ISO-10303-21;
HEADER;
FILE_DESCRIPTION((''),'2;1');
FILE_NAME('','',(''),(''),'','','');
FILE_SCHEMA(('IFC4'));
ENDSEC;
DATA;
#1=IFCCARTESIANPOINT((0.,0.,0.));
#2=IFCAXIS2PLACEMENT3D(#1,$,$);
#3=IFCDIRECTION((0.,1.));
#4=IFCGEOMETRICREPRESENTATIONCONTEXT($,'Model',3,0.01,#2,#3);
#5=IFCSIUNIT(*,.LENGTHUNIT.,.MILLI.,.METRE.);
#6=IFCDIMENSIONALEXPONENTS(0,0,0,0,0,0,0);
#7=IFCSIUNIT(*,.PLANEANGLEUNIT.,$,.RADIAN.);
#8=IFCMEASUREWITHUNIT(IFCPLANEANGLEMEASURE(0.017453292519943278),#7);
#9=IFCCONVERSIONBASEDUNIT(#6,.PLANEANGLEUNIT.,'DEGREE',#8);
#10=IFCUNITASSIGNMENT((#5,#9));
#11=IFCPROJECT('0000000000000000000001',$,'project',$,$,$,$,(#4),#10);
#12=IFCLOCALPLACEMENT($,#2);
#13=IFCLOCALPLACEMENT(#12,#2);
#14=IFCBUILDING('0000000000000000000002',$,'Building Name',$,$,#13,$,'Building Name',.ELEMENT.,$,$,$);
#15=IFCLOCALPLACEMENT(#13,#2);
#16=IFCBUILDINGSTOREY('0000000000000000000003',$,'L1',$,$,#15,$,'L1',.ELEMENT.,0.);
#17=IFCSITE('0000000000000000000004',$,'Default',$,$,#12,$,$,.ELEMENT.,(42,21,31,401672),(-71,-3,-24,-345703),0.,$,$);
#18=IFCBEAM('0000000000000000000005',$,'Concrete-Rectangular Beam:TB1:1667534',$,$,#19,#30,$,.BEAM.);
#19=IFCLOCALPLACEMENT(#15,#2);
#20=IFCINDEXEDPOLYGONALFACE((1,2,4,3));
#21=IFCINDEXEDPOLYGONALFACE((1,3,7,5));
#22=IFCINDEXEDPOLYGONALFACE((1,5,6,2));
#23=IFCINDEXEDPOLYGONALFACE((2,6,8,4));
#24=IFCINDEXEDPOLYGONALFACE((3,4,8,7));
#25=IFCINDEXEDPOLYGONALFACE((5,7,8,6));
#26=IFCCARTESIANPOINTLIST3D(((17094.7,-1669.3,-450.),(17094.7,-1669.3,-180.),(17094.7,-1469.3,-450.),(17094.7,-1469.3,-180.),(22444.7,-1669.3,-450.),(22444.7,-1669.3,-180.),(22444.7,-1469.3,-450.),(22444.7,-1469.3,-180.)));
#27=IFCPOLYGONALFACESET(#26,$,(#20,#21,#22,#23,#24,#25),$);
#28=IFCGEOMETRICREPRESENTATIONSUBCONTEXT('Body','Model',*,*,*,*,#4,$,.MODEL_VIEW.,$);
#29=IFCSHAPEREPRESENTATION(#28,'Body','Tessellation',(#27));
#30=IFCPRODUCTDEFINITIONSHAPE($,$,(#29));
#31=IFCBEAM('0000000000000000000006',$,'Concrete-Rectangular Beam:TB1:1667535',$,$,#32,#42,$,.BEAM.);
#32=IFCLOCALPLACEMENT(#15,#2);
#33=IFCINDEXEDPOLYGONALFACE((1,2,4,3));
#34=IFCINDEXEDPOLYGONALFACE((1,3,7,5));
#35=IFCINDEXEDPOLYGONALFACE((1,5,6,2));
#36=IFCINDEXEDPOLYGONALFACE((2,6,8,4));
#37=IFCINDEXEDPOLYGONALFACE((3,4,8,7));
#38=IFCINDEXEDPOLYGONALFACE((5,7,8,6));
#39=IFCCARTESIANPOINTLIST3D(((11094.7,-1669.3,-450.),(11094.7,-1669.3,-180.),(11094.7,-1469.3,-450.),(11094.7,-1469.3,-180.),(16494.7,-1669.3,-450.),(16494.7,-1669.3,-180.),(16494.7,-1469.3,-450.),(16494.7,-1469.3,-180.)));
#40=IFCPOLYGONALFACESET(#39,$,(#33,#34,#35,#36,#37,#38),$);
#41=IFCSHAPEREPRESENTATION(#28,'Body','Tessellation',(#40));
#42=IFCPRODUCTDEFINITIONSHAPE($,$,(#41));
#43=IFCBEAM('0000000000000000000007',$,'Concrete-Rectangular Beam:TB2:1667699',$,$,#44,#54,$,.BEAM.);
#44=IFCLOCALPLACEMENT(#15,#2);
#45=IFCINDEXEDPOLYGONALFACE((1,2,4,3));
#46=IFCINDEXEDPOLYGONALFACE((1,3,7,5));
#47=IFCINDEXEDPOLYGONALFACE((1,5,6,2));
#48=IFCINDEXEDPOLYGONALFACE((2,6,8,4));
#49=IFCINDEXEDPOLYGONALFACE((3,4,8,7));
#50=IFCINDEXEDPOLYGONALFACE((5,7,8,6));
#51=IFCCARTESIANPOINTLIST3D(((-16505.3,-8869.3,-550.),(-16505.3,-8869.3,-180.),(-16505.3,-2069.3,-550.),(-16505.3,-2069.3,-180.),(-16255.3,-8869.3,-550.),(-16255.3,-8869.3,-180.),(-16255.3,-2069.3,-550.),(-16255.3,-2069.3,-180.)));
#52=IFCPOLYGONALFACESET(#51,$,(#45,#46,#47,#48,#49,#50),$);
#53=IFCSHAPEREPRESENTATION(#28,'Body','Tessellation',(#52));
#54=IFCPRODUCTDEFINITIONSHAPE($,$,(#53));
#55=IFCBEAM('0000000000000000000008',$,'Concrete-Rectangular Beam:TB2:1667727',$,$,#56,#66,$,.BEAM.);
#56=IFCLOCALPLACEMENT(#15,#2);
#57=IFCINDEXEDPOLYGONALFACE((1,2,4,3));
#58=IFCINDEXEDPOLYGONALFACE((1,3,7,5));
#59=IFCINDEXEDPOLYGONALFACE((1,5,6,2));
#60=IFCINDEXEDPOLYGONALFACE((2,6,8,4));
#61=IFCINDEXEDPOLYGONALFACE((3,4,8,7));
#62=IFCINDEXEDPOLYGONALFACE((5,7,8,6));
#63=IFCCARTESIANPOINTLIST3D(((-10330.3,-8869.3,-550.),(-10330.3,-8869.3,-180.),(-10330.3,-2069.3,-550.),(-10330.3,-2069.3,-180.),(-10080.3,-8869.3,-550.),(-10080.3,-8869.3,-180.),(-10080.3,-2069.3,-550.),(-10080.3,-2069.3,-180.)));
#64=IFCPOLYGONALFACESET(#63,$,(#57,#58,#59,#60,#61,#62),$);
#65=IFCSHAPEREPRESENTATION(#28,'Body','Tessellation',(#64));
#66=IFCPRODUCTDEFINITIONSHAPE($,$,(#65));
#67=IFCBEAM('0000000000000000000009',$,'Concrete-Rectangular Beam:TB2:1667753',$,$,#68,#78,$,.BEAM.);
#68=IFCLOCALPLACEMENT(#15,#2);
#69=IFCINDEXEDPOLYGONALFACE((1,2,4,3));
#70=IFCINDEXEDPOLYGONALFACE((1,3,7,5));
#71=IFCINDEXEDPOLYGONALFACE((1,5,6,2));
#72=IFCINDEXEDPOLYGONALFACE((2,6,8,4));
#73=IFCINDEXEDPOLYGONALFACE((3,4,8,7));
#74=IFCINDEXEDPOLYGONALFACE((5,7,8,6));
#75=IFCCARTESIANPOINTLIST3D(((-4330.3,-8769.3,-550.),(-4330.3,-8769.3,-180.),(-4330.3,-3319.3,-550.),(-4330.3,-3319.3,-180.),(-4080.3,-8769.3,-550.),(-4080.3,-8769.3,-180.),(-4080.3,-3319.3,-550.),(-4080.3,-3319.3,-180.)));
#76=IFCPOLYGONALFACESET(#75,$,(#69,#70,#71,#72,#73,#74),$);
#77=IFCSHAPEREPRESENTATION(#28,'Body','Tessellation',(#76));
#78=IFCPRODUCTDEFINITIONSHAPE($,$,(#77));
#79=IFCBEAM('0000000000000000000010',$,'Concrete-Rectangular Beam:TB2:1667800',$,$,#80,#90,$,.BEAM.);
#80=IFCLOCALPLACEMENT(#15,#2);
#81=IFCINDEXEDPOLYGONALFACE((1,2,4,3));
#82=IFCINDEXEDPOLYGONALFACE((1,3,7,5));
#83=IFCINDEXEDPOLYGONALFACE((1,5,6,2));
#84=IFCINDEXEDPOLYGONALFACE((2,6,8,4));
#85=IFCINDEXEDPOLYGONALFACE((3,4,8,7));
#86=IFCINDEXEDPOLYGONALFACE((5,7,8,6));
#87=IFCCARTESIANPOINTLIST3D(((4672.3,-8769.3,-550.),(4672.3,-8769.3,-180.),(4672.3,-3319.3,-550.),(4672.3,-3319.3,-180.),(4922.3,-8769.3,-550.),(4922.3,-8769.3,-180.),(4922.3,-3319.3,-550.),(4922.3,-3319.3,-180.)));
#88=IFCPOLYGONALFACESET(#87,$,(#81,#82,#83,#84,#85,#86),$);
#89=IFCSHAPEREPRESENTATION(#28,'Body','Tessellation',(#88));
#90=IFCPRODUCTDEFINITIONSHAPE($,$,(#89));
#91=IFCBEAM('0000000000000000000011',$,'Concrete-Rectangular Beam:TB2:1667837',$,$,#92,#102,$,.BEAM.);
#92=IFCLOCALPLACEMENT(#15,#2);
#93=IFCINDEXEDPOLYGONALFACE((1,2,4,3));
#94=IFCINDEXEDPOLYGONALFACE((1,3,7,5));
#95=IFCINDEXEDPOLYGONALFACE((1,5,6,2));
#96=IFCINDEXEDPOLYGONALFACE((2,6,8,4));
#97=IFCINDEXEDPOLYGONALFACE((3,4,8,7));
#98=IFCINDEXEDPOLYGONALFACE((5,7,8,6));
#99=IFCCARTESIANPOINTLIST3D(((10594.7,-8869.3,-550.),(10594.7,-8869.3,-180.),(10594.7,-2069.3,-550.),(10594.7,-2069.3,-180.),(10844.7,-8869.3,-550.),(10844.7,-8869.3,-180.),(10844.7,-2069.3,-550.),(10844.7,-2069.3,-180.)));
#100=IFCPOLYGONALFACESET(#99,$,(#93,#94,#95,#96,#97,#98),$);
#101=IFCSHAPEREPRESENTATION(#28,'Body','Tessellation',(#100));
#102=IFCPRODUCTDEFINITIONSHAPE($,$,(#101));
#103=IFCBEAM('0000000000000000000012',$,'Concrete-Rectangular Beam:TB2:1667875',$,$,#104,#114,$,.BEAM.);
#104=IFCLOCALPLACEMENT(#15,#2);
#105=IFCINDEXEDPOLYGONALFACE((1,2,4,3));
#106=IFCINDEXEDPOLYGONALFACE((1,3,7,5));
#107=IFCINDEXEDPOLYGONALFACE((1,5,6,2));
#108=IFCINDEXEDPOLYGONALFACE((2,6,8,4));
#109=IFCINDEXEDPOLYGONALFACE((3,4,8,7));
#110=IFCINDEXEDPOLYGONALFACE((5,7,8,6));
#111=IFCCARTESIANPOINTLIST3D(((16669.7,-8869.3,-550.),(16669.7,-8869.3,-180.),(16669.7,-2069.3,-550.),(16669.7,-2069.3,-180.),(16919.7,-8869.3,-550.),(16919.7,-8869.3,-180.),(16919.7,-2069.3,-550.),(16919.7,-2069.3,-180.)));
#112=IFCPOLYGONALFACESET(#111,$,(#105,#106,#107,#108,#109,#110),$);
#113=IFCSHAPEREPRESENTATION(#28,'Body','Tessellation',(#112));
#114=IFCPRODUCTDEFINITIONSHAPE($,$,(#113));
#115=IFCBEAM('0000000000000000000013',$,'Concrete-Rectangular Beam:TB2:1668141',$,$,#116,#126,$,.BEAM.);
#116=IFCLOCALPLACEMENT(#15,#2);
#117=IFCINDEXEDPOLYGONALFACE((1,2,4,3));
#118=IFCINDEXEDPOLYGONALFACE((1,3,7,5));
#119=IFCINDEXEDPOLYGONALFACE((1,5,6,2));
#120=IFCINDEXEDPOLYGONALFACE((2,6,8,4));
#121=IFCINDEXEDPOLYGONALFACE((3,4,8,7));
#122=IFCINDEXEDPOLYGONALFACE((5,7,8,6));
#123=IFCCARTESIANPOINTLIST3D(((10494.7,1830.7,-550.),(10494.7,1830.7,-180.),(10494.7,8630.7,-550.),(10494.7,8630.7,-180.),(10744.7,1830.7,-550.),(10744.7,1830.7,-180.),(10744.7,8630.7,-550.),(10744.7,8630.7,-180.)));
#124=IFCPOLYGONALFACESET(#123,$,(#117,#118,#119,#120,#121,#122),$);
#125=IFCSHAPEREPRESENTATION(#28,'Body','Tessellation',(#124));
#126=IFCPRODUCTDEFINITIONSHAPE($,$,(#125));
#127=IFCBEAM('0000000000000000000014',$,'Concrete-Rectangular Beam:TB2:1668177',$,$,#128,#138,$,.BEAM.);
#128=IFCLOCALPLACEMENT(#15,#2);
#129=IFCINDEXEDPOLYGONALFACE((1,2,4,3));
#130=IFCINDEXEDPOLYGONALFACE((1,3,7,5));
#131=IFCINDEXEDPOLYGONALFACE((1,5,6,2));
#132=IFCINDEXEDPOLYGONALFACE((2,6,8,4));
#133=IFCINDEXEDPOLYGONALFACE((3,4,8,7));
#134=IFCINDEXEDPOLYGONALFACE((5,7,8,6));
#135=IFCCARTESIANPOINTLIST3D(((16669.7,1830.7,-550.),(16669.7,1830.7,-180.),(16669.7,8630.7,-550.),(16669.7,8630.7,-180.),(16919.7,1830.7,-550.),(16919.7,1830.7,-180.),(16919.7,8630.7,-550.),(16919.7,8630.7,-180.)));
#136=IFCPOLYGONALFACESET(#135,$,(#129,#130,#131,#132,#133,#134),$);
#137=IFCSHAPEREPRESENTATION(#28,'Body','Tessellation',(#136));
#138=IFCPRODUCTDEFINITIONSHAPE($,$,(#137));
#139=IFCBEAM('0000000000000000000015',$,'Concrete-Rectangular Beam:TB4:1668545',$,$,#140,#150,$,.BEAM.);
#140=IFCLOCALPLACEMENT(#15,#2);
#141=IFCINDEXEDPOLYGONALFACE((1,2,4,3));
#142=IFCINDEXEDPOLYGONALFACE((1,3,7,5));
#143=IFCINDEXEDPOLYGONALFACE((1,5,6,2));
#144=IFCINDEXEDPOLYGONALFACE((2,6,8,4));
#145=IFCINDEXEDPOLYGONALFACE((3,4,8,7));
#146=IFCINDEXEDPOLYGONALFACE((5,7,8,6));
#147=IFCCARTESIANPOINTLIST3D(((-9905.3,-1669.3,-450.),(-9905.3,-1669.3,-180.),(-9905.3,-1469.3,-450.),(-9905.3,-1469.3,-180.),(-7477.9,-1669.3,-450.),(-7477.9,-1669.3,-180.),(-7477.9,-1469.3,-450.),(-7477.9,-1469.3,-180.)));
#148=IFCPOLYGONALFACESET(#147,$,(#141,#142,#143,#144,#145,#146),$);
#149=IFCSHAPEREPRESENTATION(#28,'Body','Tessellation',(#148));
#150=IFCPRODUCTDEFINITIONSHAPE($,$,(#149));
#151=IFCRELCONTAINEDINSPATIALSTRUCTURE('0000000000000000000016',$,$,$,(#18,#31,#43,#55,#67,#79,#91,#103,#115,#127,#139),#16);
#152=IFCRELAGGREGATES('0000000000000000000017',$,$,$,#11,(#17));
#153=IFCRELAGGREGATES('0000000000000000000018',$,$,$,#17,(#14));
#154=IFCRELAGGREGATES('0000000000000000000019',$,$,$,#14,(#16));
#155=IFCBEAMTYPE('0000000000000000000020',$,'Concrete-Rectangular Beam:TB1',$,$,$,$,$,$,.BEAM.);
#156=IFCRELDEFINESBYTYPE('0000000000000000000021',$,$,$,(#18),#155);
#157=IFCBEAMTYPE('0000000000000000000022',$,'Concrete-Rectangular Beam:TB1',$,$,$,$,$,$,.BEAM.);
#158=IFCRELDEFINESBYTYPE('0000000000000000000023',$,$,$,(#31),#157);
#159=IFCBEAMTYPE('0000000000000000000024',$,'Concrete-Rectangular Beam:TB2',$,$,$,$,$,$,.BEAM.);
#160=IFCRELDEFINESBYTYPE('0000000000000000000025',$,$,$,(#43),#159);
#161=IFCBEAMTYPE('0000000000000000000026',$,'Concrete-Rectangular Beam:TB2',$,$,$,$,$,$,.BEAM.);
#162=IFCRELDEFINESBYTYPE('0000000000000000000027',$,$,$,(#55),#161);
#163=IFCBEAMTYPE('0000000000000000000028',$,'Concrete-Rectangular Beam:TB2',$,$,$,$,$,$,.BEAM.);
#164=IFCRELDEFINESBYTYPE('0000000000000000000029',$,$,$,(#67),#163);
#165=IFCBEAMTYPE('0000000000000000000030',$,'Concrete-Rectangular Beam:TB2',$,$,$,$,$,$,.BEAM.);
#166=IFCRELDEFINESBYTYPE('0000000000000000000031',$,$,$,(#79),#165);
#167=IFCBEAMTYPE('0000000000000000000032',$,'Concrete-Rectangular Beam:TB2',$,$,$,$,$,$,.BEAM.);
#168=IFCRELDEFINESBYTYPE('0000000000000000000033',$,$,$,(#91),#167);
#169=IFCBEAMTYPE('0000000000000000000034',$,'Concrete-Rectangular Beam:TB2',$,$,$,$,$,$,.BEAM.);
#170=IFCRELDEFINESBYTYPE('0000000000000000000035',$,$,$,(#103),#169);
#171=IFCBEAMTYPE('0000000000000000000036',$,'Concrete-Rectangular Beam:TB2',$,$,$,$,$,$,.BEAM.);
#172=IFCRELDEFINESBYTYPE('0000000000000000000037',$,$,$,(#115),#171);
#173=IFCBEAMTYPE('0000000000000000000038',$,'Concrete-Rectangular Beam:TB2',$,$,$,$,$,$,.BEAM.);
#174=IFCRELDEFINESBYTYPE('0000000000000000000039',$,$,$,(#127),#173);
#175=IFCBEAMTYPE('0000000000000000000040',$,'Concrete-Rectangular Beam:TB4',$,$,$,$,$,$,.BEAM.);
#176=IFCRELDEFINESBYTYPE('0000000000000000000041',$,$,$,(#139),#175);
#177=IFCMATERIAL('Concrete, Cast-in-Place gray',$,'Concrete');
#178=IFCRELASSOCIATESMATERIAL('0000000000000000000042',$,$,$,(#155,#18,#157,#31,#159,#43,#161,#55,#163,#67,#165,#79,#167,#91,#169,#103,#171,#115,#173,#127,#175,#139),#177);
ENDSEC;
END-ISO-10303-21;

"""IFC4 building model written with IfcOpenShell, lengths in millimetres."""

from ifc_helpers import new_model, entity, si_unit, converted_unit, direction, frame, origin, place, context, subcontext, project, spatial, indexed_curve, outline, extrude, source, transform, mapped, material, type_object, type_shapes, element, save


model = new_model("IFC4")

# Units and contexts
model_context = context("Model", 3, precision=0.01, world=origin(), true_north=direction((0.0, 1.0)))
body_context = subcontext(model_context, "Body", "Model", "MODEL_VIEW")
ifc_project = project(units=[si_unit("LENGTHUNIT", "METRE", prefix="MILLI"), converted_unit("PLANEANGLEUNIT", "DEGREE", entity("IfcPlaneAngleMeasure", 0.017453292519943278), si_unit("PLANEANGLEUNIT", "RADIAN"), dimensions=[0, 0, 0, 0, 0, 0, 0])], contexts=[model_context])

# Site, building, storey
site_placement = place(None, origin())
site = spatial("IfcSite", under=ifc_project, at=site_placement, Name="Default", CompositionType="ELEMENT", RefLatitude=(42, 21, 31, 401672), RefLongitude=(-71, -3, -24, -345703), RefElevation=0.0)
building_placement = place(site_placement, origin())
building = spatial("IfcBuilding", under=site, at=building_placement, Name="Building Name", LongName="Building Name", CompositionType="ELEMENT")
storey_placement = place(building_placement, origin())
storey = spatial("IfcBuildingStorey", under=building, at=storey_placement, Name="L1", LongName="L1", CompositionType="ELEMENT", Elevation=0.0)

# Beams
ifc_material = material(Name="Concrete, Cast-in-Place gray", Category="Concrete")
beam_type_1 = type_object("IfcBeamType", Name="Concrete-Rectangular Beam:TB1", PredefinedType="BEAM", material=ifc_material)
shared_shape_1 = source(origin(), body_context, "Body", "SweptSolid", [
    extrude(outline(indexed_curve([(-135.0, -100.0), (135.0, -100.0), (135.0, 100.0), (-135.0, 100.0), (-135.0, -100.0)], self_intersect=False)), frame((22444.7, -1569.3, -315.0), z_axis=(-1.0, 0.0, 0.0), x_axis=(0.0, 0.0, -1.0)), (0.0, 0.0, 1.0), 5350.0),
])
type_shapes(beam_type_1, [shared_shape_1])
beam_1_placement = place(storey_placement, origin())
element("IfcBeam", 1, at=beam_1_placement, inside=storey, type_object=beam_type_1, material=ifc_material, Name="Concrete-Rectangular Beam:TB1:1667534", PredefinedType="BEAM", context=body_context, shape_type="MappedRepresentation", body=[
    mapped(shared_shape_1, transform((0.0, 0.0, 0.0), scale=1.0)),
])
beam_type_2 = type_object("IfcBeamType", Name="Concrete-Rectangular Beam:TB1", PredefinedType="BEAM", material=ifc_material)
shared_shape_2 = source(origin(), body_context, "Body", "SweptSolid", [
    extrude(outline(indexed_curve([(-135.0, -100.0), (135.0, -100.0), (135.0, 100.0), (-135.0, 100.0), (-135.0, -100.0)], self_intersect=False)), frame((16494.7, -1569.3, -315.0), z_axis=(-1.0, 0.0, 0.0), x_axis=(0.0, 0.0, -1.0)), (0.0, 0.0, 1.0), 5400.0),
])
type_shapes(beam_type_2, [shared_shape_2])
beam_2_placement = place(storey_placement, origin())
element("IfcBeam", 2, at=beam_2_placement, inside=storey, type_object=beam_type_2, material=ifc_material, Name="Concrete-Rectangular Beam:TB1:1667535", PredefinedType="BEAM", context=body_context, shape_type="MappedRepresentation", body=[
    mapped(shared_shape_2, transform((0.0, 0.0, 0.0), scale=1.0)),
])
beam_type_3 = type_object("IfcBeamType", Name="Concrete-Rectangular Beam:TB2", PredefinedType="BEAM", material=ifc_material)
shared_shape_3 = source(origin(), body_context, "Body", "SweptSolid", [
    extrude(outline(indexed_curve([(-125.0, -185.0), (125.0, -185.0), (125.0, 185.0), (-125.0, 185.0), (-125.0, -185.0)], self_intersect=False)), frame((-16380.3, -8869.3, -365.0), z_axis=(0.0, 1.0, 0.0), x_axis=(-1.0, 0.0, 0.0)), (0.0, 0.0, 1.0), 6800.0),
])
type_shapes(beam_type_3, [shared_shape_3])
beam_3_placement = place(storey_placement, origin())
element("IfcBeam", 3, at=beam_3_placement, inside=storey, type_object=beam_type_3, material=ifc_material, Name="Concrete-Rectangular Beam:TB2:1667699", PredefinedType="BEAM", context=body_context, shape_type="MappedRepresentation", body=[
    mapped(shared_shape_3, transform((0.0, 0.0, 0.0), scale=1.0)),
])
beam_type_4 = type_object("IfcBeamType", Name="Concrete-Rectangular Beam:TB2", PredefinedType="BEAM", material=ifc_material)
shared_shape_4 = source(origin(), body_context, "Body", "SweptSolid", [
    extrude(outline(indexed_curve([(-125.0, -185.0), (125.0, -185.0), (125.0, 185.0), (-125.0, 185.0), (-125.0, -185.0)], self_intersect=False)), frame((-10205.3, -8869.3, -365.0), z_axis=(0.0, 1.0, 0.0), x_axis=(-1.0, 0.0, 0.0)), (0.0, 0.0, 1.0), 6800.0),
])
type_shapes(beam_type_4, [shared_shape_4])
beam_4_placement = place(storey_placement, origin())
element("IfcBeam", 4, at=beam_4_placement, inside=storey, type_object=beam_type_4, material=ifc_material, Name="Concrete-Rectangular Beam:TB2:1667727", PredefinedType="BEAM", context=body_context, shape_type="MappedRepresentation", body=[
    mapped(shared_shape_4, transform((0.0, 0.0, 0.0), scale=1.0)),
])
beam_type_5 = type_object("IfcBeamType", Name="Concrete-Rectangular Beam:TB2", PredefinedType="BEAM", material=ifc_material)
shared_shape_5 = source(origin(), body_context, "Body", "SweptSolid", [
    extrude(outline(indexed_curve([(-125.0, -185.0), (125.0, -185.0), (125.0, 185.0), (-125.0, 185.0), (-125.0, -185.0)], self_intersect=False)), frame((-4205.3, -8769.3, -365.0), z_axis=(0.0, 1.0, 0.0), x_axis=(-1.0, 0.0, 0.0)), (0.0, 0.0, 1.0), 5450.0),
])
type_shapes(beam_type_5, [shared_shape_5])
beam_5_placement = place(storey_placement, origin())
element("IfcBeam", 5, at=beam_5_placement, inside=storey, type_object=beam_type_5, material=ifc_material, Name="Concrete-Rectangular Beam:TB2:1667753", PredefinedType="BEAM", context=body_context, shape_type="MappedRepresentation", body=[
    mapped(shared_shape_5, transform((0.0, 0.0, 0.0), scale=1.0)),
])
beam_type_6 = type_object("IfcBeamType", Name="Concrete-Rectangular Beam:TB2", PredefinedType="BEAM", material=ifc_material)
shared_shape_6 = source(origin(), body_context, "Body", "SweptSolid", [
    extrude(outline(indexed_curve([(-125.0, -185.0), (125.0, -185.0), (125.0, 185.0), (-125.0, 185.0), (-125.0, -185.0)], self_intersect=False)), frame((4797.3, -8769.3, -365.0), z_axis=(0.0, 1.0, 0.0), x_axis=(-1.0, 0.0, 0.0)), (0.0, 0.0, 1.0), 5450.0),
])
type_shapes(beam_type_6, [shared_shape_6])
beam_6_placement = place(storey_placement, origin())
element("IfcBeam", 6, at=beam_6_placement, inside=storey, type_object=beam_type_6, material=ifc_material, Name="Concrete-Rectangular Beam:TB2:1667800", PredefinedType="BEAM", context=body_context, shape_type="MappedRepresentation", body=[
    mapped(shared_shape_6, transform((0.0, 0.0, 0.0), scale=1.0)),
])
beam_type_7 = type_object("IfcBeamType", Name="Concrete-Rectangular Beam:TB2", PredefinedType="BEAM", material=ifc_material)
shared_shape_7 = source(origin(), body_context, "Body", "SweptSolid", [
    extrude(outline(indexed_curve([(-125.0, -185.0), (125.0, -185.0), (125.0, 185.0), (-125.0, 185.0), (-125.0, -185.0)], self_intersect=False)), frame((10719.7, -8869.3, -365.0), z_axis=(0.0, 1.0, 0.0), x_axis=(-1.0, 0.0, 0.0)), (0.0, 0.0, 1.0), 6800.0),
])
type_shapes(beam_type_7, [shared_shape_7])
beam_7_placement = place(storey_placement, origin())
element("IfcBeam", 7, at=beam_7_placement, inside=storey, type_object=beam_type_7, material=ifc_material, Name="Concrete-Rectangular Beam:TB2:1667837", PredefinedType="BEAM", context=body_context, shape_type="MappedRepresentation", body=[
    mapped(shared_shape_7, transform((0.0, 0.0, 0.0), scale=1.0)),
])
beam_type_8 = type_object("IfcBeamType", Name="Concrete-Rectangular Beam:TB2", PredefinedType="BEAM", material=ifc_material)
shared_shape_8 = source(origin(), body_context, "Body", "SweptSolid", [
    extrude(outline(indexed_curve([(-125.0, -185.0), (125.0, -185.0), (125.0, 185.0), (-125.0, 185.0), (-125.0, -185.0)], self_intersect=False)), frame((16794.7, -8869.3, -365.0), z_axis=(0.0, 1.0, 0.0), x_axis=(-1.0, 0.0, 0.0)), (0.0, 0.0, 1.0), 6800.0),
])
type_shapes(beam_type_8, [shared_shape_8])
beam_8_placement = place(storey_placement, origin())
element("IfcBeam", 8, at=beam_8_placement, inside=storey, type_object=beam_type_8, material=ifc_material, Name="Concrete-Rectangular Beam:TB2:1667875", PredefinedType="BEAM", context=body_context, shape_type="MappedRepresentation", body=[
    mapped(shared_shape_8, transform((0.0, 0.0, 0.0), scale=1.0)),
])
beam_type_9 = type_object("IfcBeamType", Name="Concrete-Rectangular Beam:TB2", PredefinedType="BEAM", material=ifc_material)
shared_shape_9 = source(origin(), body_context, "Body", "SweptSolid", [
    extrude(outline(indexed_curve([(-125.0, -185.0), (125.0, -185.0), (125.0, 185.0), (-125.0, 185.0), (-125.0, -185.0)], self_intersect=False)), frame((10619.7, 8630.7, -365.0), z_axis=(0.0, -1.0, 0.0), x_axis=(-1.0, 0.0, 0.0)), (0.0, 0.0, 1.0), 6800.0),
])
type_shapes(beam_type_9, [shared_shape_9])
beam_9_placement = place(storey_placement, origin())
element("IfcBeam", 9, at=beam_9_placement, inside=storey, type_object=beam_type_9, material=ifc_material, Name="Concrete-Rectangular Beam:TB2:1668141", PredefinedType="BEAM", context=body_context, shape_type="MappedRepresentation", body=[
    mapped(shared_shape_9, transform((0.0, 0.0, 0.0), scale=1.0)),
])
beam_type_10 = type_object("IfcBeamType", Name="Concrete-Rectangular Beam:TB2", PredefinedType="BEAM", material=ifc_material)
shared_shape_10 = source(origin(), body_context, "Body", "SweptSolid", [
    extrude(outline(indexed_curve([(-125.0, -185.0), (125.0, -185.0), (125.0, 185.0), (-125.0, 185.0), (-125.0, -185.0)], self_intersect=False)), frame((16794.7, 8630.7, -365.0), z_axis=(0.0, -1.0, 0.0), x_axis=(-1.0, 0.0, 0.0)), (0.0, 0.0, 1.0), 6800.0),
])
type_shapes(beam_type_10, [shared_shape_10])
beam_10_placement = place(storey_placement, origin())
element("IfcBeam", 10, at=beam_10_placement, inside=storey, type_object=beam_type_10, material=ifc_material, Name="Concrete-Rectangular Beam:TB2:1668177", PredefinedType="BEAM", context=body_context, shape_type="MappedRepresentation", body=[
    mapped(shared_shape_10, transform((0.0, 0.0, 0.0), scale=1.0)),
])
beam_type_11 = type_object("IfcBeamType", Name="Concrete-Rectangular Beam:TB4", PredefinedType="BEAM", material=ifc_material)
shared_shape_11 = source(origin(), body_context, "Body", "SweptSolid", [
    extrude(outline(indexed_curve([(-135.0, -100.0), (135.0, -100.0), (135.0, 100.0), (-135.0, 100.0), (-135.0, -100.0)], self_intersect=False)), frame((-7477.9, -1569.3, -315.0), z_axis=(-1.0, 0.0, 0.0), x_axis=(0.0, 0.0, -1.0)), (0.0, 0.0, 1.0), 2427.4),
])
type_shapes(beam_type_11, [shared_shape_11])
beam_11_placement = place(storey_placement, origin())
element("IfcBeam", 11, at=beam_11_placement, inside=storey, type_object=beam_type_11, material=ifc_material, Name="Concrete-Rectangular Beam:TB4:1668545", PredefinedType="BEAM", context=body_context, shape_type="MappedRepresentation", body=[
    mapped(shared_shape_11, transform((0.0, 0.0, 0.0), scale=1.0)),
])

save(model, "model.ifc")
